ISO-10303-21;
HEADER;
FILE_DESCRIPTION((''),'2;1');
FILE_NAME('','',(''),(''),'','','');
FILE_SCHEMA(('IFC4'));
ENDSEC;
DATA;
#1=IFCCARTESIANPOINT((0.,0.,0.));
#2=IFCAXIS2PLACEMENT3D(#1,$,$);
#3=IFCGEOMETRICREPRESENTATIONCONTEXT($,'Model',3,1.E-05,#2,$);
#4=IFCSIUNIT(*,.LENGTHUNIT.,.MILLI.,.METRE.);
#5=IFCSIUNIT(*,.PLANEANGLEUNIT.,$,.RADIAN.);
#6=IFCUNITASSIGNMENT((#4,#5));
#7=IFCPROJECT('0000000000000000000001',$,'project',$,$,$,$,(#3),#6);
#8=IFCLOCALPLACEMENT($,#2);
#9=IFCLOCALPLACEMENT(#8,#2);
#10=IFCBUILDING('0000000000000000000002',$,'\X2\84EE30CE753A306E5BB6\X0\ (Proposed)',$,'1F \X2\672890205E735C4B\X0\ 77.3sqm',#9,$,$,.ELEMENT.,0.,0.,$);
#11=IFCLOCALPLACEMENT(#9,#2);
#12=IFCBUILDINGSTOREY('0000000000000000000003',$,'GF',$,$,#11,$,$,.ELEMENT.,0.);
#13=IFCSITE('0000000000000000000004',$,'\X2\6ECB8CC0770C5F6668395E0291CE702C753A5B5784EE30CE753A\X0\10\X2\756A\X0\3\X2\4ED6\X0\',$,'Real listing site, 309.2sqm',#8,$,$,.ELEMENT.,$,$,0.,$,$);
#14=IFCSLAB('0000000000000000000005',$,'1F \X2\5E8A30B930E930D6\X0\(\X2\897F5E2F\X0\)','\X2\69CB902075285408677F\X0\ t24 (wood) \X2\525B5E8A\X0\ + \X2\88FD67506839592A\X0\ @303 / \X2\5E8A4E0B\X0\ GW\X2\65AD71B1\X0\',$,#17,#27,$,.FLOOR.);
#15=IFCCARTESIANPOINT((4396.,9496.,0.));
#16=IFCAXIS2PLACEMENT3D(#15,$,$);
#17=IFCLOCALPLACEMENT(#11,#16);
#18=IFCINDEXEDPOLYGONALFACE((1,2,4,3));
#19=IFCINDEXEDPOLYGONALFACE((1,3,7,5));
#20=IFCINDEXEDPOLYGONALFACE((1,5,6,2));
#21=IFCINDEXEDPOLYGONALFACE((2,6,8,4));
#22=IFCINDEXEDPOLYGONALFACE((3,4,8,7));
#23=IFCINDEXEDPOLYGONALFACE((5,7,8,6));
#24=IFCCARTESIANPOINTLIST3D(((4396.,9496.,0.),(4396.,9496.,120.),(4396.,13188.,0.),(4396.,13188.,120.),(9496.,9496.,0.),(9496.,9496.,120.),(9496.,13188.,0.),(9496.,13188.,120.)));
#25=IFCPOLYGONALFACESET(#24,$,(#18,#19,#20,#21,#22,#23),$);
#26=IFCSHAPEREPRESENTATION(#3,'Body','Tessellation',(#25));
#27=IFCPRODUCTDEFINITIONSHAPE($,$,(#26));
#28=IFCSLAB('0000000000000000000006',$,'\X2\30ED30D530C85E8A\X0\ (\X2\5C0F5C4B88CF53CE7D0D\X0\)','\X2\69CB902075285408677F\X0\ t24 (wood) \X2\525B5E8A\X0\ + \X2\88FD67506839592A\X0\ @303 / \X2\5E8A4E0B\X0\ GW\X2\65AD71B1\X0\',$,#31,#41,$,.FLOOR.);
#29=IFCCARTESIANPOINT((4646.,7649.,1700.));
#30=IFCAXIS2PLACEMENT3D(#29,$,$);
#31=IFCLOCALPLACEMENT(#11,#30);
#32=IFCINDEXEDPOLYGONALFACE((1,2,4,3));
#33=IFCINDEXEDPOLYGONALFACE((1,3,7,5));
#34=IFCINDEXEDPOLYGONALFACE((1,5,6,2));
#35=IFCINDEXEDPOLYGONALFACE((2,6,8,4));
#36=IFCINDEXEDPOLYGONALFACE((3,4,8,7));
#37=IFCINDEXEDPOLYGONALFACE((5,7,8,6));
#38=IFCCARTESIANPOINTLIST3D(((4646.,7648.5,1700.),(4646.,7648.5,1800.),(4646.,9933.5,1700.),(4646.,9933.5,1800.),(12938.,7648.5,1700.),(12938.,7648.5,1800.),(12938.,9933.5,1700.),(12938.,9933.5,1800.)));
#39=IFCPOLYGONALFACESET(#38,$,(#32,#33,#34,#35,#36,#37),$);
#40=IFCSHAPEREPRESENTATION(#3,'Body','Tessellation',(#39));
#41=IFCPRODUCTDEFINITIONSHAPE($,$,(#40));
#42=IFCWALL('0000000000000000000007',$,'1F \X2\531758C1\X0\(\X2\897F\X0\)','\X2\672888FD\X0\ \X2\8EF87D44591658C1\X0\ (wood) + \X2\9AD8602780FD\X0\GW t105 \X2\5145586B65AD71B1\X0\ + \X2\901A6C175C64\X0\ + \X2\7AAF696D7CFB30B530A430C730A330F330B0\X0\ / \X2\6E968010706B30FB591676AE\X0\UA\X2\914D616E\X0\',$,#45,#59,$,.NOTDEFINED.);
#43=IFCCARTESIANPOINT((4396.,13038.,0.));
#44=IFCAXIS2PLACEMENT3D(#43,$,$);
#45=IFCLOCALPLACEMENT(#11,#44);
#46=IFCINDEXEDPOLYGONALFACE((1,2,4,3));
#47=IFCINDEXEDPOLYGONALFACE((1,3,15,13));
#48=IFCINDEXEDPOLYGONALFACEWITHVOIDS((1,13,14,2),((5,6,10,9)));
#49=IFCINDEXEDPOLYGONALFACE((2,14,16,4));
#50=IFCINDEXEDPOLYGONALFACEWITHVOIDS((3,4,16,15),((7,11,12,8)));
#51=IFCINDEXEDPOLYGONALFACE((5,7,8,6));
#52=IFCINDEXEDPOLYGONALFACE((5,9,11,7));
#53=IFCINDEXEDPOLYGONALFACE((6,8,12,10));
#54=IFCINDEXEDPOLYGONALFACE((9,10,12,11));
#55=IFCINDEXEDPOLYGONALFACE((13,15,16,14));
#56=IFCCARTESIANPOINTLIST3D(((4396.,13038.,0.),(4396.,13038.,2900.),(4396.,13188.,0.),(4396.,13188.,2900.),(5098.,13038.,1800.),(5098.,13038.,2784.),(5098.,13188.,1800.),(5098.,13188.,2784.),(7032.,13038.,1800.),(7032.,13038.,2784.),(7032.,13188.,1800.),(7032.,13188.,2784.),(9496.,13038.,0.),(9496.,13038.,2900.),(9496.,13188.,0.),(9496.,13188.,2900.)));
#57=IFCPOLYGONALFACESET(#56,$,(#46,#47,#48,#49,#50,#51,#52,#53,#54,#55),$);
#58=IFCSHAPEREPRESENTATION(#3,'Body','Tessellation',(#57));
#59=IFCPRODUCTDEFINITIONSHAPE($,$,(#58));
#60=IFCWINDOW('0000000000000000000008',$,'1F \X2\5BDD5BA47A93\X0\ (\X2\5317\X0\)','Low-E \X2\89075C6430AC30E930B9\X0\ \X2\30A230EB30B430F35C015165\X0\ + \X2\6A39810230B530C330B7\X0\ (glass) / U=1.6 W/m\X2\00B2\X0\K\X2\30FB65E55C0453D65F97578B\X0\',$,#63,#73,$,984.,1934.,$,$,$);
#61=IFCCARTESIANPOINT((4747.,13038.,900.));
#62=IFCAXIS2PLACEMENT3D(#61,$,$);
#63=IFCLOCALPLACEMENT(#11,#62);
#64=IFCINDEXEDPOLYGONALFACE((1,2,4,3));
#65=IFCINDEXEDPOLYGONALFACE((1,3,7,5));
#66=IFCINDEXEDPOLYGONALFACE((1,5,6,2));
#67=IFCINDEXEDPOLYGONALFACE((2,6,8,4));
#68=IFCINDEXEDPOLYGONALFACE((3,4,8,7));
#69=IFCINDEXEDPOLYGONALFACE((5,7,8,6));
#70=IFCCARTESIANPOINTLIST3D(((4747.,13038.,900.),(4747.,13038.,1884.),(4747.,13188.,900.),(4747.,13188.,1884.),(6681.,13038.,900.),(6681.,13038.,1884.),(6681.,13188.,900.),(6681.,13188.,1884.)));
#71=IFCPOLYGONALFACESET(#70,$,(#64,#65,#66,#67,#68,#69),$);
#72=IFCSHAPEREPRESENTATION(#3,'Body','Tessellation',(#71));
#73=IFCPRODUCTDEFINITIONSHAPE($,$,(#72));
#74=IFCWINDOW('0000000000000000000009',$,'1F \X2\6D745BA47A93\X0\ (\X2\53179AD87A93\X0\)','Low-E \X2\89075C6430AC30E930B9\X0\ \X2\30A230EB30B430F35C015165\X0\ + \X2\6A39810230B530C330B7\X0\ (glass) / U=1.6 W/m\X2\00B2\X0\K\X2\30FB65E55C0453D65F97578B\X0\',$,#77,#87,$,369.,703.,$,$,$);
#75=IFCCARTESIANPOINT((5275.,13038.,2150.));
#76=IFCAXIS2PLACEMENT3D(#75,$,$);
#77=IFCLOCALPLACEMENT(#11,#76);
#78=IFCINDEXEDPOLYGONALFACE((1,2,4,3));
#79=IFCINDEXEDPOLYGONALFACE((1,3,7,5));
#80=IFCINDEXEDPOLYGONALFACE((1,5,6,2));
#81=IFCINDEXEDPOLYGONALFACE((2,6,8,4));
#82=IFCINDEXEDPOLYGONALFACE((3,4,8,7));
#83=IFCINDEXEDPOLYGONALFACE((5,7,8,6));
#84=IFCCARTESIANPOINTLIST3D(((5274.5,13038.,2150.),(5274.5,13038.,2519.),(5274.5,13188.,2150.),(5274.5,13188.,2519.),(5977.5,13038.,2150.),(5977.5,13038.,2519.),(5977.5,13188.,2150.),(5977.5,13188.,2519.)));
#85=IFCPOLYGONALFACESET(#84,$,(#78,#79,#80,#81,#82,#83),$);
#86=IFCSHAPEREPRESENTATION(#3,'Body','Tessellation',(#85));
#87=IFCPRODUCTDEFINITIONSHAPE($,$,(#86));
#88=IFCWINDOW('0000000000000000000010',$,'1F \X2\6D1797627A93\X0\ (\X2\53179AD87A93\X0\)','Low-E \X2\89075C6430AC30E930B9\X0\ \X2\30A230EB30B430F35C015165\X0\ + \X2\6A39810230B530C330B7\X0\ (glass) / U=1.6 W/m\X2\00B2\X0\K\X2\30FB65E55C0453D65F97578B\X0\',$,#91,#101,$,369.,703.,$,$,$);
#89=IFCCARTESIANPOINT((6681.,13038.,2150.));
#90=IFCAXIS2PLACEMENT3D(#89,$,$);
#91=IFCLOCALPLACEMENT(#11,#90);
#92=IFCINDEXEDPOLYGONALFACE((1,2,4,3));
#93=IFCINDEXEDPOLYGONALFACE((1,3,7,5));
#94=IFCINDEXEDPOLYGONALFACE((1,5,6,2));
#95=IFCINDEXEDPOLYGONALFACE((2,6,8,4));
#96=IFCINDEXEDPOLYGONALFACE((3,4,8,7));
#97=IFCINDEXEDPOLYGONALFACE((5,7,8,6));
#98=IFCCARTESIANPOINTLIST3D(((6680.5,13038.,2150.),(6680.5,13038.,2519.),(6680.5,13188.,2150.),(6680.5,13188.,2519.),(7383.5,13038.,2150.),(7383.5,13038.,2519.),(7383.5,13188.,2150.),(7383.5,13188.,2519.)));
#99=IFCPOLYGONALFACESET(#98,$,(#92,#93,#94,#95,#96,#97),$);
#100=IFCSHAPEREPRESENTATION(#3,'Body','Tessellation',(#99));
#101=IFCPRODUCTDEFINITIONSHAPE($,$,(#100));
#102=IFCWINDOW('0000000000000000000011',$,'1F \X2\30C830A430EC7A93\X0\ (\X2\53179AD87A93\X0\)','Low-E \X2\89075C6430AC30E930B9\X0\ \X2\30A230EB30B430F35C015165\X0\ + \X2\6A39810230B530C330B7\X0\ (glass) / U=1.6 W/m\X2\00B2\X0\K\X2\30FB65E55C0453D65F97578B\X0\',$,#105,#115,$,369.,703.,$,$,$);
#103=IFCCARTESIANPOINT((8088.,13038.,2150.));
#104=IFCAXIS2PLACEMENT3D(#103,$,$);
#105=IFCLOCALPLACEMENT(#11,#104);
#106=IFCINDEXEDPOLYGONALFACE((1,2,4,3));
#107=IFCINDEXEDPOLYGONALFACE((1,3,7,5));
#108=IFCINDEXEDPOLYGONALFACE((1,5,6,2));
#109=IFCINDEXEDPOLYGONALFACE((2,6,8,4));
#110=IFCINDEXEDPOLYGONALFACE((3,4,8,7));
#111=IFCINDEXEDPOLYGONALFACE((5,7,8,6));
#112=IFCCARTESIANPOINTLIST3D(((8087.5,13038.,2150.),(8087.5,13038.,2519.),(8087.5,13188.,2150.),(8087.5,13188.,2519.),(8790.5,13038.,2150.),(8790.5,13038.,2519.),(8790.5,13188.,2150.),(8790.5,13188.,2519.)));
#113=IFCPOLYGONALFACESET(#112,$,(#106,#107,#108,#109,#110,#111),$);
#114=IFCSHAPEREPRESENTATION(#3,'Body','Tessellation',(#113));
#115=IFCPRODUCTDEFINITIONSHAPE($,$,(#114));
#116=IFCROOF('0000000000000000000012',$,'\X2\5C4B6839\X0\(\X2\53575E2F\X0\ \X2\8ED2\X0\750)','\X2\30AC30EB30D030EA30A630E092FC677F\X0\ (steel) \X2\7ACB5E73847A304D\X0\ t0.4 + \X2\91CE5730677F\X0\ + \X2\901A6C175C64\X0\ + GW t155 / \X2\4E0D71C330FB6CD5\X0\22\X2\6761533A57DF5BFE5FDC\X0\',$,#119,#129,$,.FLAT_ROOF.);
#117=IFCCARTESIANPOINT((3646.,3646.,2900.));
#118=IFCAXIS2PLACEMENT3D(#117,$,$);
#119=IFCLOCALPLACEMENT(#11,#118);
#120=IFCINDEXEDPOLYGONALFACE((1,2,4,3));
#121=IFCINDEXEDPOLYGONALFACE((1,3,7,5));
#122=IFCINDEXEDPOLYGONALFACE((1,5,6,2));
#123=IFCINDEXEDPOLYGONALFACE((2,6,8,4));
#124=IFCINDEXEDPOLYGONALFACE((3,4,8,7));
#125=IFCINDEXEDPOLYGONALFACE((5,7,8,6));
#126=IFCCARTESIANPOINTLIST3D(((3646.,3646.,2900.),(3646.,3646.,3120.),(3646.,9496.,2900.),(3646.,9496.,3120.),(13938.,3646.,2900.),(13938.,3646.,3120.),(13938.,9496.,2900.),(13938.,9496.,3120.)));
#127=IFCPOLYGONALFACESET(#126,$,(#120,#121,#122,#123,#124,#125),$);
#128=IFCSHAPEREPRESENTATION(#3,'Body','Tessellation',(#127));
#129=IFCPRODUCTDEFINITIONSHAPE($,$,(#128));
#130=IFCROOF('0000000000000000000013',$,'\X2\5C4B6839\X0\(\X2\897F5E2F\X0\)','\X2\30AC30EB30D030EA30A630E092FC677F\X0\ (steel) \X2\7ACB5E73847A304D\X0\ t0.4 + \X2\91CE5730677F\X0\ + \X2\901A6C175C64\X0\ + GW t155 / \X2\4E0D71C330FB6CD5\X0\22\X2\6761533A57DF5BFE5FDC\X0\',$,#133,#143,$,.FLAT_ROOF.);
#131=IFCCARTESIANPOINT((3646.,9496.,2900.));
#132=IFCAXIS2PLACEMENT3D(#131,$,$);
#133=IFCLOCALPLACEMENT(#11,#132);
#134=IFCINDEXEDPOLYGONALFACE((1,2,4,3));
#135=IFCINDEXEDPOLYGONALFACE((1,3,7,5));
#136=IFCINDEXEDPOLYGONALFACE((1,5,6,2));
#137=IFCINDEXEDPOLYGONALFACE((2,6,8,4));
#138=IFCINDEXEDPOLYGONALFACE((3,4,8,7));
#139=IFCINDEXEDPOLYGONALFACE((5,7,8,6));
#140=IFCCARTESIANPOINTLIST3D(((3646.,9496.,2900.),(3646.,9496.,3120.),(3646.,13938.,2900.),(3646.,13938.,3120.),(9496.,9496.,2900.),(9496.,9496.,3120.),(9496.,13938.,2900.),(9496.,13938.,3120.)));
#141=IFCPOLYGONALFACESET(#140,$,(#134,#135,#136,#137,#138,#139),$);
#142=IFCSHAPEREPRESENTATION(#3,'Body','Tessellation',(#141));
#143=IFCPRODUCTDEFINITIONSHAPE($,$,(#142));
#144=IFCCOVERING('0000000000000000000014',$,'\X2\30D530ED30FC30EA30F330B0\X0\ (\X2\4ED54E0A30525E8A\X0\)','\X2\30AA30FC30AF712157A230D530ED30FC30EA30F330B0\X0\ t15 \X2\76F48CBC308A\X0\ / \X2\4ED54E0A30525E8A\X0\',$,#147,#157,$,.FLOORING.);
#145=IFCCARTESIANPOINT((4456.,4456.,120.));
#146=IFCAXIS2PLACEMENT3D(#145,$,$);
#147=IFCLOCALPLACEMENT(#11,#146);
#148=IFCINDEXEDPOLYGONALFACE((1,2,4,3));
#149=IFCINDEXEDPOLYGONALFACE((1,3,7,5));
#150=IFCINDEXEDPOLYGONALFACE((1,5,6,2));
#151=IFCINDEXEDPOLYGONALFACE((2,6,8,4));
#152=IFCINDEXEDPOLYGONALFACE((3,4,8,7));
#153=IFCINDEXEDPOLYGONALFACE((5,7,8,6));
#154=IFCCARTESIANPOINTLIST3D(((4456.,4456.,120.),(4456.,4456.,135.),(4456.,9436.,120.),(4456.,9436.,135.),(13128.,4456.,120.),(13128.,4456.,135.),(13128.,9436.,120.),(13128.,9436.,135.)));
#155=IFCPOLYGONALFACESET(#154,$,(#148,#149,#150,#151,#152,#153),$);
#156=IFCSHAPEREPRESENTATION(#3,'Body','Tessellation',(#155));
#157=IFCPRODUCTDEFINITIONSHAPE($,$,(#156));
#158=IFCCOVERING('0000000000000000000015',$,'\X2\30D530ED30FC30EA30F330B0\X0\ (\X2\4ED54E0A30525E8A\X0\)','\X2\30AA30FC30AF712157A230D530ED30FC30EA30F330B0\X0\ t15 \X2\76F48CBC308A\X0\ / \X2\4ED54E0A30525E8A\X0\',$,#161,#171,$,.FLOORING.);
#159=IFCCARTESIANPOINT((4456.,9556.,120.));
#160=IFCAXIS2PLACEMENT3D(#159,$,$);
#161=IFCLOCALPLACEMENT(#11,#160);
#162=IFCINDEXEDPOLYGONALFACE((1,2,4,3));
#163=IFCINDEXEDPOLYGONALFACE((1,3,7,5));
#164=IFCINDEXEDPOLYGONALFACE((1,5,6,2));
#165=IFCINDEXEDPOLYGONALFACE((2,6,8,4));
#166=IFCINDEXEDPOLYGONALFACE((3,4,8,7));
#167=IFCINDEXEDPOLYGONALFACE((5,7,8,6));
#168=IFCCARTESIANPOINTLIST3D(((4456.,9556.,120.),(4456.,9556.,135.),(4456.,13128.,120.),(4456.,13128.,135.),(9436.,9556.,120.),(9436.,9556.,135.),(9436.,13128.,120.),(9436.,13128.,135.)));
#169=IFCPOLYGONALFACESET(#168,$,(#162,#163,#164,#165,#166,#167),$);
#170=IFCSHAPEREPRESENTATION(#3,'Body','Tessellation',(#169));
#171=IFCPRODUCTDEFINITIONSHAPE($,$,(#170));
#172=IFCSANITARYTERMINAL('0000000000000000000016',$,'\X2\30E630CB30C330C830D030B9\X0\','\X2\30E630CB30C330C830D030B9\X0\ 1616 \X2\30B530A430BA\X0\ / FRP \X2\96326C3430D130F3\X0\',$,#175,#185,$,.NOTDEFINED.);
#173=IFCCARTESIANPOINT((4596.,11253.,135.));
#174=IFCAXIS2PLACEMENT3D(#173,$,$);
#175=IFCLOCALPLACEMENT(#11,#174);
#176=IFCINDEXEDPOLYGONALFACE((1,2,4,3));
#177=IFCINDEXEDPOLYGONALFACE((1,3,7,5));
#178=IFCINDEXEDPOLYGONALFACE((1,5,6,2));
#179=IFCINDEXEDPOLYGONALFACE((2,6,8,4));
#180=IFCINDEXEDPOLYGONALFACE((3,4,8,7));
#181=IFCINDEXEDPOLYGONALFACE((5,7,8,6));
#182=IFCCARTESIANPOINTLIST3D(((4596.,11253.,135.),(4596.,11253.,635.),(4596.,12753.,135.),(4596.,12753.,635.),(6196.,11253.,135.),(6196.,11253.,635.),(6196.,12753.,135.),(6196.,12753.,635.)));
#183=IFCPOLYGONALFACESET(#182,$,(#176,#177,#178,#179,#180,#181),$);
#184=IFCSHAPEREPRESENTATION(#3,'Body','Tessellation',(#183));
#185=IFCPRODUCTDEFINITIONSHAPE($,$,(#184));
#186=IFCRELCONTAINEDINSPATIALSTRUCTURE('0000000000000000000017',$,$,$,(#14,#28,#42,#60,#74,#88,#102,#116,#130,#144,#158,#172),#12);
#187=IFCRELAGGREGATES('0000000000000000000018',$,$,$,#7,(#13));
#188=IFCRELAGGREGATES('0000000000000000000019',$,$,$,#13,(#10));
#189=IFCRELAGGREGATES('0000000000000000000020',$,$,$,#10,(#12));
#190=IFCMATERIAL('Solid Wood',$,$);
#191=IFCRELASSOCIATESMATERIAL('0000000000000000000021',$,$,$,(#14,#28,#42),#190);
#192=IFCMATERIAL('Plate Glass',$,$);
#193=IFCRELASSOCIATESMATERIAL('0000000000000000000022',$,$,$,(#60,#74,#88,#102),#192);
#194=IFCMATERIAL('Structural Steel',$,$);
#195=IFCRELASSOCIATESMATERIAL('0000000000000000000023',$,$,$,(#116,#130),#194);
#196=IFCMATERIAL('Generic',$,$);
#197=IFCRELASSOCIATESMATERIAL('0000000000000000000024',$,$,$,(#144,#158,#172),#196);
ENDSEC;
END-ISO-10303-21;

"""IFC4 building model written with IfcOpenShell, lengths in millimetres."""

from ifc_helpers import new_model, si_unit, frame, frame_2d, origin, place, context, project, spatial, rectangle, extrude, material, element, fill, save


model = new_model("IFC4")

# Units and contexts
model_context = context("Model", 3, precision=1e-05, world=origin())
ifc_project = project(units=[si_unit("LENGTHUNIT", "METRE", prefix="MILLI"), si_unit("PLANEANGLEUNIT", "RADIAN")], contexts=[model_context])

# Site, building, storey
site_placement = place(None, origin())
site = spatial("IfcSite", under=ifc_project, at=site_placement, Name="滋賀県彦根市野瀬町字蓮ノ町10番3他", ObjectType="Real listing site, 309.2sqm", CompositionType="ELEMENT", RefElevation=0.0)
building_placement = place(site_placement, origin())
building = spatial("IfcBuilding", under=site, at=building_placement, Name="蓮ノ町の家 (Proposed)", ObjectType="1F 木造平屋 77.3sqm", CompositionType="ELEMENT", ElevationOfRefHeight=0.0, ElevationOfTerrain=0.0)
storey_placement = place(building_placement, origin())
storey = spatial("IfcBuildingStorey", under=building, at=storey_placement, Name="GF", CompositionType="ELEMENT", Elevation=0.0)

# Slabs
ifc_material_1 = material(Name="Solid Wood")
slab_1_placement = place(storey_placement, frame((4396.0, 9496.0, 0.0)))
element("IfcSlab", 1, at=slab_1_placement, inside=storey, material=ifc_material_1, Name="1F 床スラブ(西帯)", Description="構造用合板 t24 (wood) 剛床 + 製材根太 @303 / 床下 GW断熱", PredefinedType="FLOOR", context=model_context, shape_type="SweptSolid", body=[
    extrude(rectangle(XDim=5100.0, YDim=3692.0, at=frame_2d((2550.0, 1846.0))), frame((4396.0, 9496.0, 0.0)), (0.0, 0.0, 1.0), 120.0),
])
slab_2_placement = place(storey_placement, frame((4646.0, 7649.0, 1700.0)))
element("IfcSlab", 2, at=slab_2_placement, inside=storey, material=ifc_material_1, Name="ロフト床 (小屋裏収納)", Description="構造用合板 t24 (wood) 剛床 + 製材根太 @303 / 床下 GW断熱", PredefinedType="FLOOR", context=model_context, shape_type="SweptSolid", body=[
    extrude(rectangle(XDim=8292.0, YDim=2285.0, at=frame_2d((4146.0, 1142.0))), frame((4646.0, 7649.0, 1700.0)), (0.0, 0.0, 1.0), 100.0),
])

# Shared definitions
ifc_material_2 = material(Name="Plate Glass")

# Wall, openings, windows
wall_1_placement = place(storey_placement, frame((4396.0, 13038.0, 0.0)))
wall_1 = element("IfcWall", 3, at=wall_1_placement, inside=storey, material=ifc_material_1, Name="1F 北壁(西)", Description="木製 軸組外壁 (wood) + 高性能GW t105 充填断熱 + 通気層 + 窯業系サイディング / 準耐火・外皮UA配慮", PredefinedType="NOTDEFINED", context=model_context, shape_type="SweptSolid", body=[
    extrude(rectangle(XDim=5100.0, YDim=150.0, at=frame_2d((2550.0, 75.0))), frame((4396.0, 13038.0, 0.0)), (0.0, 0.0, 1.0), 2900.0),
])
opening_1_placement = place(storey_placement, frame((4747.0, 13038.0, 900.0)))
opening_1 = element("IfcOpeningElement", 4, at=opening_1_placement, cuts=wall_1, PredefinedType="NOTDEFINED", context=model_context, shape_type="SweptSolid", body=[
    extrude(rectangle(XDim=1934.0, YDim=150.0, at=frame_2d((967.0, 75.0))), frame((4747.0, 13038.0, 900.0)), (0.0, 0.0, 1.0), 984.0),
])
opening_2_placement = place(storey_placement, frame((5275.0, 13038.0, 2150.0)))
opening_2 = element("IfcOpeningElement", 5, at=opening_2_placement, cuts=wall_1, PredefinedType="NOTDEFINED", context=model_context, shape_type="SweptSolid", body=[
    extrude(rectangle(XDim=703.0, YDim=150.0, at=frame_2d((351.0, 75.0))), frame((5275.0, 13038.0, 2150.0)), (0.0, 0.0, 1.0), 369.0),
])
opening_3_placement = place(storey_placement, frame((6681.0, 13038.0, 2150.0)))
opening_3 = element("IfcOpeningElement", 6, at=opening_3_placement, cuts=wall_1, PredefinedType="NOTDEFINED", context=model_context, shape_type="SweptSolid", body=[
    extrude(rectangle(XDim=703.0, YDim=150.0, at=frame_2d((351.0, 75.0))), frame((6681.0, 13038.0, 2150.0)), (0.0, 0.0, 1.0), 369.0),
])
opening_4_placement = place(storey_placement, frame((8088.0, 13038.0, 2150.0)))
opening_4 = element("IfcOpeningElement", 7, at=opening_4_placement, cuts=wall_1, PredefinedType="NOTDEFINED", context=model_context, shape_type="SweptSolid", body=[
    extrude(rectangle(XDim=703.0, YDim=150.0, at=frame_2d((351.0, 75.0))), frame((8088.0, 13038.0, 2150.0)), (0.0, 0.0, 1.0), 369.0),
])
window_1_placement = place(storey_placement, frame((4747.0, 13038.0, 900.0)))
window_1 = element("IfcWindow", 8, at=window_1_placement, inside=storey, material=ifc_material_2, Name="1F 寝室窓 (北)", Description="Low-E 複層ガラス アルゴン封入 + 樹脂サッシ (glass) / U=1.6 W/m²K・日射取得型", OverallHeight=984.0, OverallWidth=1934.0, context=model_context, shape_type="SweptSolid", body=[
    extrude(rectangle(XDim=1934.0, YDim=150.0, at=frame_2d((967.0, 75.0))), frame((4747.0, 13038.0, 900.0)), (0.0, 0.0, 1.0), 984.0),
])
fill(opening_1, window_1)
window_2_placement = place(storey_placement, frame((5275.0, 13038.0, 2150.0)))
window_2 = element("IfcWindow", 9, at=window_2_placement, inside=storey, material=ifc_material_2, Name="1F 浴室窓 (北高窓)", Description="Low-E 複層ガラス アルゴン封入 + 樹脂サッシ (glass) / U=1.6 W/m²K・日射取得型", OverallHeight=369.0, OverallWidth=703.0, context=model_context, shape_type="SweptSolid", body=[
    extrude(rectangle(XDim=703.0, YDim=150.0, at=frame_2d((351.0, 75.0))), frame((5275.0, 13038.0, 2150.0)), (0.0, 0.0, 1.0), 369.0),
])
fill(opening_2, window_2)
window_3_placement = place(storey_placement, frame((6681.0, 13038.0, 2150.0)))
window_3 = element("IfcWindow", 10, at=window_3_placement, inside=storey, material=ifc_material_2, Name="1F 洗面窓 (北高窓)", Description="Low-E 複層ガラス アルゴン封入 + 樹脂サッシ (glass) / U=1.6 W/m²K・日射取得型", OverallHeight=369.0, OverallWidth=703.0, context=model_context, shape_type="SweptSolid", body=[
    extrude(rectangle(XDim=703.0, YDim=150.0, at=frame_2d((351.0, 75.0))), frame((6681.0, 13038.0, 2150.0)), (0.0, 0.0, 1.0), 369.0),
])
fill(opening_3, window_3)
window_4_placement = place(storey_placement, frame((8088.0, 13038.0, 2150.0)))
window_4 = element("IfcWindow", 11, at=window_4_placement, inside=storey, material=ifc_material_2, Name="1F トイレ窓 (北高窓)", Description="Low-E 複層ガラス アルゴン封入 + 樹脂サッシ (glass) / U=1.6 W/m²K・日射取得型", OverallHeight=369.0, OverallWidth=703.0, context=model_context, shape_type="SweptSolid", body=[
    extrude(rectangle(XDim=703.0, YDim=150.0, at=frame_2d((351.0, 75.0))), frame((8088.0, 13038.0, 2150.0)), (0.0, 0.0, 1.0), 369.0),
])
fill(opening_4, window_4)

# Roofs
ifc_material_3 = material(Name="Structural Steel")
roof_1_placement = place(storey_placement, frame((3646.0, 3646.0, 2900.0)))
element("IfcRoof", 12, at=roof_1_placement, inside=storey, material=ifc_material_3, Name="屋根(南帯 軒750)", Description="ガルバリウム鋼板 (steel) 立平葺き t0.4 + 野地板 + 通気層 + GW t155 / 不燃・法22条区域対応", PredefinedType="FLAT_ROOF", context=model_context, shape_type="SweptSolid", body=[
    extrude(rectangle(XDim=10292.0, YDim=5850.0, at=frame_2d((5146.0, 2925.0))), frame((3646.0, 3646.0, 2900.0)), (0.0, 0.0, 1.0), 220.0),
])
roof_2_placement = place(storey_placement, frame((3646.0, 9496.0, 2900.0)))
element("IfcRoof", 13, at=roof_2_placement, inside=storey, material=ifc_material_3, Name="屋根(西帯)", Description="ガルバリウム鋼板 (steel) 立平葺き t0.4 + 野地板 + 通気層 + GW t155 / 不燃・法22条区域対応", PredefinedType="FLAT_ROOF", context=model_context, shape_type="SweptSolid", body=[
    extrude(rectangle(XDim=5850.0, YDim=4442.0, at=frame_2d((2925.0, 2221.0))), frame((3646.0, 9496.0, 2900.0)), (0.0, 0.0, 1.0), 220.0),
])

# Coverings
ifc_material_4 = material(Name="Generic")
covering_1_placement = place(storey_placement, frame((4456.0, 4456.0, 120.0)))
element("IfcCovering", 14, at=covering_1_placement, inside=storey, material=ifc_material_4, Name="フローリング (仕上げ床)", Description="オーク無垢フローリング t15 直貼り / 仕上げ床", PredefinedType="FLOORING", context=model_context, shape_type="SweptSolid", body=[
    extrude(rectangle(XDim=8672.0, YDim=4980.0, at=frame_2d((4336.0, 2490.0))), frame((4456.0, 4456.0, 120.0)), (0.0, 0.0, 1.0), 15.0),
])
covering_2_placement = place(storey_placement, frame((4456.0, 9556.0, 120.0)))
element("IfcCovering", 15, at=covering_2_placement, inside=storey, material=ifc_material_4, Name="フローリング (仕上げ床)", Description="オーク無垢フローリング t15 直貼り / 仕上げ床", PredefinedType="FLOORING", context=model_context, shape_type="SweptSolid", body=[
    extrude(rectangle(XDim=4980.0, YDim=3572.0, at=frame_2d((2490.0, 1786.0))), frame((4456.0, 9556.0, 120.0)), (0.0, 0.0, 1.0), 15.0),
])

# Sanitary terminal
sanitary_terminal_placement = place(storey_placement, frame((4596.0, 11253.0, 135.0)))
element("IfcSanitaryTerminal", 16, at=sanitary_terminal_placement, inside=storey, material=ifc_material_4, Name="ユニットバス", Description="ユニットバス 1616 サイズ / FRP 防水パン", PredefinedType="NOTDEFINED", context=model_context, shape_type="SweptSolid", body=[
    extrude(rectangle(XDim=1600.0, YDim=1500.0, at=frame_2d((800.0, 750.0))), frame((4596.0, 11253.0, 135.0)), (0.0, 0.0, 1.0), 500.0),
])

save(model, "model.ifc")
